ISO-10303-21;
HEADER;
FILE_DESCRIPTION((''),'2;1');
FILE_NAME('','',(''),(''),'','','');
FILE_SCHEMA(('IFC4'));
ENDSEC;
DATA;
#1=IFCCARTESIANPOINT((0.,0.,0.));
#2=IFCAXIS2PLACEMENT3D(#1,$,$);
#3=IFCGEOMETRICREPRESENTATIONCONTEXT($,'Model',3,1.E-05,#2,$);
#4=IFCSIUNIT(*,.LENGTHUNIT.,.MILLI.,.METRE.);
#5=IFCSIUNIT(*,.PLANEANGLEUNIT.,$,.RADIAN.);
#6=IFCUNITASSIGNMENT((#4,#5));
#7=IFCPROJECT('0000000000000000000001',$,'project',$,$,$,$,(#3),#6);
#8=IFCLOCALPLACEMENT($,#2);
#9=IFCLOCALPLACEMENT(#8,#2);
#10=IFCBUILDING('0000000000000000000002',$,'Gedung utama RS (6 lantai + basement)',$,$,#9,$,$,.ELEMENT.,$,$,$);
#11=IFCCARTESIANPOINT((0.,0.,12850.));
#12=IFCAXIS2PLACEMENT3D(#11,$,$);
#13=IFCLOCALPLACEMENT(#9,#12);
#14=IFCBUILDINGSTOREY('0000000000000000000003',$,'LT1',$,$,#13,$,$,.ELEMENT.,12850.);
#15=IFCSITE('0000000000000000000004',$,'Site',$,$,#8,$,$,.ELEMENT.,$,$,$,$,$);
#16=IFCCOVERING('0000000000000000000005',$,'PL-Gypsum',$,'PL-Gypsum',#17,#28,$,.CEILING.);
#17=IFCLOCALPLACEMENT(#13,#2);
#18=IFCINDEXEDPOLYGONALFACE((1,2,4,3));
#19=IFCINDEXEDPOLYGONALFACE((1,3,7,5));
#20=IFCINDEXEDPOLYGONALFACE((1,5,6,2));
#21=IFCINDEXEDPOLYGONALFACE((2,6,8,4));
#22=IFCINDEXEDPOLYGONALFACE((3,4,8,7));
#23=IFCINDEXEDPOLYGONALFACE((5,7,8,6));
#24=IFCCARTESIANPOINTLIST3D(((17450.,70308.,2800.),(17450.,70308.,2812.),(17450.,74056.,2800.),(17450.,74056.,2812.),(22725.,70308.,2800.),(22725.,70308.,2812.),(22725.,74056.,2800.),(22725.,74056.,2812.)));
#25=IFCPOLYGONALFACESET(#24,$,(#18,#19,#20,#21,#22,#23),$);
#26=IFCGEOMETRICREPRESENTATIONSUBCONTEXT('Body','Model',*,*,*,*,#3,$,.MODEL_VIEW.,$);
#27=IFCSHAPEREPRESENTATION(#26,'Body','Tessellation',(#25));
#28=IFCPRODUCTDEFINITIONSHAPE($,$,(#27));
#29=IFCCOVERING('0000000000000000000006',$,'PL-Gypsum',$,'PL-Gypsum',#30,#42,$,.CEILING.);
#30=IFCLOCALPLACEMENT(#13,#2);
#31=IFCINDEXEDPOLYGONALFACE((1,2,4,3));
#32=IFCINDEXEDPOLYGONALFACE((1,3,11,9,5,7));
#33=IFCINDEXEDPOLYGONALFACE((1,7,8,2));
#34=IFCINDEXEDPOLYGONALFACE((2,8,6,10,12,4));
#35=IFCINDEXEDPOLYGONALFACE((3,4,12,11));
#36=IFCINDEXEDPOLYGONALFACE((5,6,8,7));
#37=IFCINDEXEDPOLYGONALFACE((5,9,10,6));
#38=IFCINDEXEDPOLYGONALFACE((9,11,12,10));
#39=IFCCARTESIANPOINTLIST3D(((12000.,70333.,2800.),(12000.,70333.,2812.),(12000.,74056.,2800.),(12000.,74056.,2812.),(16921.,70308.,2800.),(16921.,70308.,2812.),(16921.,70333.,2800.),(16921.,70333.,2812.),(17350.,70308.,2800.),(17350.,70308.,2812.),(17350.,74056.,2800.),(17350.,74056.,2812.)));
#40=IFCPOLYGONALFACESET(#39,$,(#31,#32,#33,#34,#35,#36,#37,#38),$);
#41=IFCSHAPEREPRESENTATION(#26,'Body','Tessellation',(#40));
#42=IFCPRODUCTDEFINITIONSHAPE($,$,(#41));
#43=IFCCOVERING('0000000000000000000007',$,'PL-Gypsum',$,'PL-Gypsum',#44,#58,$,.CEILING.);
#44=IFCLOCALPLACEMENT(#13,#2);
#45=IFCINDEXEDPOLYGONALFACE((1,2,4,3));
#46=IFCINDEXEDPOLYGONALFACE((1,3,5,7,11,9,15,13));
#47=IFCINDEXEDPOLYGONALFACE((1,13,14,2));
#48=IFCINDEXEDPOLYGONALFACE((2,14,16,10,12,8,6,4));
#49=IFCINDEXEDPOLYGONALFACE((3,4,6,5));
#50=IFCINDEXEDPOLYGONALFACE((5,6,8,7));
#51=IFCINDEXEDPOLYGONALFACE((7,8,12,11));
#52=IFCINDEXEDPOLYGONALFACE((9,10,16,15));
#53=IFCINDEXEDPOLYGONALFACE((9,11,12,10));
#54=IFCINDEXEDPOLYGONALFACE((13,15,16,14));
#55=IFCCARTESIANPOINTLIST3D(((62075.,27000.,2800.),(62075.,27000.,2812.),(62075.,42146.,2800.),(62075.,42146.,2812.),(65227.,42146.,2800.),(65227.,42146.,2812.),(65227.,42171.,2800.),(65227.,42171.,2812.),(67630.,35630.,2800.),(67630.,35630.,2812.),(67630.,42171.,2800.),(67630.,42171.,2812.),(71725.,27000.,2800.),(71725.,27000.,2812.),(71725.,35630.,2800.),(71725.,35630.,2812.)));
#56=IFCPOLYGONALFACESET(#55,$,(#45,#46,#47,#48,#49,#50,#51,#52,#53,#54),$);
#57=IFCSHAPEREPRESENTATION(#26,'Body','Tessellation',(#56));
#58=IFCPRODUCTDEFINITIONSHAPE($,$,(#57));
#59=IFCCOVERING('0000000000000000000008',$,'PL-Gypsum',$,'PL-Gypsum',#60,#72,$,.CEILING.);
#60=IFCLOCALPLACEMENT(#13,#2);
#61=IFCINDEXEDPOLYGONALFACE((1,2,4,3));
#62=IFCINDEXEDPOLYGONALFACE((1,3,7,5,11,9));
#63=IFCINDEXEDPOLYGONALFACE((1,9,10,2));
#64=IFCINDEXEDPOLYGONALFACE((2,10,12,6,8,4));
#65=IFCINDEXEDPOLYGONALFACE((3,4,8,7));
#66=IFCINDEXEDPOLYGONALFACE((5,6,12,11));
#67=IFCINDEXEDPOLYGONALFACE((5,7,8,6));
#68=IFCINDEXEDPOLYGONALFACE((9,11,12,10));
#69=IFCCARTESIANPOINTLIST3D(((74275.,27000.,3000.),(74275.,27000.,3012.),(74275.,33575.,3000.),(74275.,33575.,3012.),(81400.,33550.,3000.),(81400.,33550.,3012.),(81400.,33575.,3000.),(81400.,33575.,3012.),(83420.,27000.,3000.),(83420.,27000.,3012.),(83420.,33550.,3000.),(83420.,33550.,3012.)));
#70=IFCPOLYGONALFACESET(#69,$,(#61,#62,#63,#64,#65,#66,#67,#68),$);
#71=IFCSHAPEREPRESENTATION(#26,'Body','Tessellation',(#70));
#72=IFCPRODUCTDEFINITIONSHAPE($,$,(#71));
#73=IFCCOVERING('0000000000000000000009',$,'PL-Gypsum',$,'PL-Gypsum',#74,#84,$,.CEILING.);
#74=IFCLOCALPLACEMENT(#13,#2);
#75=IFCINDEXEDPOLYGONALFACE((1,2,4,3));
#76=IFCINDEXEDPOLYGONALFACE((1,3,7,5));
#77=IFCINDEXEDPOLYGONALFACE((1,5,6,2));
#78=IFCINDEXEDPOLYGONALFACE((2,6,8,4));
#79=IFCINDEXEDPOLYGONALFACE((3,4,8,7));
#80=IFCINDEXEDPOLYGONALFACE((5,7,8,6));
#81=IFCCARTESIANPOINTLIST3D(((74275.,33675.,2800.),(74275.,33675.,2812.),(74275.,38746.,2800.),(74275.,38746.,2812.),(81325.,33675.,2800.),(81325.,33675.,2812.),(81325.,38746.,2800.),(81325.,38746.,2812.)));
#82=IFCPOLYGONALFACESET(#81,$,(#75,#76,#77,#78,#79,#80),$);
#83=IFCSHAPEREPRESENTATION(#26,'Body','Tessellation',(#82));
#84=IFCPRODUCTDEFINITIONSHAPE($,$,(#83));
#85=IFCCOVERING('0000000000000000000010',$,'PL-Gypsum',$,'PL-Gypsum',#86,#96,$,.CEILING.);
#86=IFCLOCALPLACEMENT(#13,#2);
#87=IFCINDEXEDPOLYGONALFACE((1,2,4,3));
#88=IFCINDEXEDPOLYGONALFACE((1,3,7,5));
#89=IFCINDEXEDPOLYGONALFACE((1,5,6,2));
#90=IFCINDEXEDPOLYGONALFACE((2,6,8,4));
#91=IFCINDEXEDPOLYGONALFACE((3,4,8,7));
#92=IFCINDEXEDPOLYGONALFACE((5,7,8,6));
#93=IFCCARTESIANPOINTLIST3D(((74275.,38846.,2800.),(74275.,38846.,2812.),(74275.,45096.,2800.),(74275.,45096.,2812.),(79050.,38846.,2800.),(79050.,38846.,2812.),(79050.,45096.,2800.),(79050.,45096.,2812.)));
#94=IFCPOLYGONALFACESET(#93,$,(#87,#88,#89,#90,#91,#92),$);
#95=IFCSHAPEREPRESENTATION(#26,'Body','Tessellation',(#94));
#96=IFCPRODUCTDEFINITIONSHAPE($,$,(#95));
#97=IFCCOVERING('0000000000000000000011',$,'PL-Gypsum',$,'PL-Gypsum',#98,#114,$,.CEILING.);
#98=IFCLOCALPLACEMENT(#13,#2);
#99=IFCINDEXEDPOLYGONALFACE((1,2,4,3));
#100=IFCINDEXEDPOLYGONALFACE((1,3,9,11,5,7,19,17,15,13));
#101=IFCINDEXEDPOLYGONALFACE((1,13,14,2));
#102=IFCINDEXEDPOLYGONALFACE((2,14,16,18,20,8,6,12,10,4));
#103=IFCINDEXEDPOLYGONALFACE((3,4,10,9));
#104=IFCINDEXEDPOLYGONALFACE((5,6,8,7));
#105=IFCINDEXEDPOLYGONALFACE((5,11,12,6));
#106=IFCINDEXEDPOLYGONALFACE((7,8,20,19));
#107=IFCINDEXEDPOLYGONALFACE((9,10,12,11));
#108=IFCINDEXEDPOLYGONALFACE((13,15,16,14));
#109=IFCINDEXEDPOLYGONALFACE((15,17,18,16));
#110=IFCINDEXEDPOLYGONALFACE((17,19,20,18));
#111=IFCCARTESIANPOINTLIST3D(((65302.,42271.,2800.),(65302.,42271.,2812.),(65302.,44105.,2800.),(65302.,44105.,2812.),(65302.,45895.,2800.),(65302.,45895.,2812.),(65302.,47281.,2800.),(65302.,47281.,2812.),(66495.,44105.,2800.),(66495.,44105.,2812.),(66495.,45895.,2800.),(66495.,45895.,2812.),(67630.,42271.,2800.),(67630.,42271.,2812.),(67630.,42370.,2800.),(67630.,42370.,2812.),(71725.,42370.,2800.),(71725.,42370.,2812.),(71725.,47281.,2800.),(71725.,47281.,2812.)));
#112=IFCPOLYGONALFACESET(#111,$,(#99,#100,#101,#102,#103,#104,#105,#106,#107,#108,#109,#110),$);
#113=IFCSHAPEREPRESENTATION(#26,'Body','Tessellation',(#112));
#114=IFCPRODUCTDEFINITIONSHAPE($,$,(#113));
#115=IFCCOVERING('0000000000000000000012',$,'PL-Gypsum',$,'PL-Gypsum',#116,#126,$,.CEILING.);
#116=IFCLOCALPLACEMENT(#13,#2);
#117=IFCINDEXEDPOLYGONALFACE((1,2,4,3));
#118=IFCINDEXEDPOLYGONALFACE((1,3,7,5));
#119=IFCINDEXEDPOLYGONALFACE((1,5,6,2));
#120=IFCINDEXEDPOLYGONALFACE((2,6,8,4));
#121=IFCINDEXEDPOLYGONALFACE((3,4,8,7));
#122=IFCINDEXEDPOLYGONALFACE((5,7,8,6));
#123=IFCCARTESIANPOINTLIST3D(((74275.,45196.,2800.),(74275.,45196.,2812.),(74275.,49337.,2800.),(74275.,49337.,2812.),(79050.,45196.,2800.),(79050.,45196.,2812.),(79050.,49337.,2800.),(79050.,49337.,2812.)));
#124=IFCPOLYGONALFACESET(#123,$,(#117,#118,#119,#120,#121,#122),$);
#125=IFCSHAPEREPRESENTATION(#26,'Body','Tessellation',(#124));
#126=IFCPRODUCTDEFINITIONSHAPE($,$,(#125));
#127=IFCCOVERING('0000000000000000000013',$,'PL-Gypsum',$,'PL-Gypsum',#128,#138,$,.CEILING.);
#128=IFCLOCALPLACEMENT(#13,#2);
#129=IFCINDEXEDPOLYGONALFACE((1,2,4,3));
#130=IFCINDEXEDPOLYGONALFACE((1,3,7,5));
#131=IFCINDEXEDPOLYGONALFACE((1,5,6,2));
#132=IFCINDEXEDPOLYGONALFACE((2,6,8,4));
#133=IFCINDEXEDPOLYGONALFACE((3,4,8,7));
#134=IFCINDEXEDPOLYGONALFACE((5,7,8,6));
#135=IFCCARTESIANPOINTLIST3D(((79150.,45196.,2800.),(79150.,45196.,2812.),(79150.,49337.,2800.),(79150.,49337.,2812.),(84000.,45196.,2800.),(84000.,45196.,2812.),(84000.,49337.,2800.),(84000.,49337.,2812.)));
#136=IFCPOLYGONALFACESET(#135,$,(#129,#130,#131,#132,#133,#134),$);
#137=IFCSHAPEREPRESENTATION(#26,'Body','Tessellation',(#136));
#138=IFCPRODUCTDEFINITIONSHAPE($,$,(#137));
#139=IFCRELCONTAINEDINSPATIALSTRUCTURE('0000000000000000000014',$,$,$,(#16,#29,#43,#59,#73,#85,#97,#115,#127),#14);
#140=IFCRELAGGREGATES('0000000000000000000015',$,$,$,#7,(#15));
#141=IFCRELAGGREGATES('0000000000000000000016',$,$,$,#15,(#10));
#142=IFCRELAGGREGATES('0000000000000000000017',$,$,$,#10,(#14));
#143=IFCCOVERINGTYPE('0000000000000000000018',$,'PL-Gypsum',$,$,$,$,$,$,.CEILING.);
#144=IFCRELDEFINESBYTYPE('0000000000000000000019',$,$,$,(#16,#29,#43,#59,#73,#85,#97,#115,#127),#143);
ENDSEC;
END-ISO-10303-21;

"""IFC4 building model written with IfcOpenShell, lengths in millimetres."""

from ifc_helpers import new_model, si_unit, frame, origin, place, context, subcontext, project, spatial, polyline, outline, extrude, type_object, element, save


model = new_model("IFC4")

# Units and contexts
model_context = context("Model", 3, precision=1e-05, world=origin())
body_context = subcontext(model_context, "Body", "Model", "MODEL_VIEW")
ifc_project = project(units=[si_unit("LENGTHUNIT", "METRE", prefix="MILLI"), si_unit("PLANEANGLEUNIT", "RADIAN")], contexts=[model_context])

# Site, building, storey
site_placement = place(None, origin())
site = spatial("IfcSite", under=ifc_project, at=site_placement, Name="Site", CompositionType="ELEMENT")
building_placement = place(site_placement, origin())
building = spatial("IfcBuilding", under=site, at=building_placement, Name="Gedung utama RS (6 lantai + basement)", CompositionType="ELEMENT")
storey_placement = place(building_placement, frame((0.0, 0.0, 12850.0)))
storey = spatial("IfcBuildingStorey", under=building, at=storey_placement, Name="LT1", CompositionType="ELEMENT", Elevation=12850.0)

# Coverings
covering_type = type_object("IfcCoveringType", Name="PL-Gypsum", PredefinedType="CEILING")
covering_1_placement = place(storey_placement, origin())
element("IfcCovering", 1, at=covering_1_placement, inside=storey, type_object=covering_type, Name="PL-Gypsum", ObjectType="PL-Gypsum", PredefinedType="CEILING", context=body_context, shape_type="SweptSolid", body=[
    extrude(outline(polyline([(17450.0, 70308.0), (22725.0, 70308.0), (22725.0, 74056.0), (17450.0, 74056.0), (17450.0, 70308.0)])), frame((0.0, 0.0, 2800.0)), (0.0, 0.0, 1.0), 12.0),
])
covering_2_placement = place(storey_placement, origin())
element("IfcCovering", 2, at=covering_2_placement, inside=storey, type_object=covering_type, Name="PL-Gypsum", ObjectType="PL-Gypsum", PredefinedType="CEILING", context=body_context, shape_type="SweptSolid", body=[
    extrude(outline(polyline([(16921.0, 70308.0), (17350.0, 70308.0), (17350.0, 74056.0), (12000.0, 74056.0), (12000.0, 70333.0), (16921.0, 70333.0), (16921.0, 70308.0)])), frame((0.0, 0.0, 2800.0)), (0.0, 0.0, 1.0), 12.0),
])
covering_3_placement = place(storey_placement, origin())
element("IfcCovering", 3, at=covering_3_placement, inside=storey, type_object=covering_type, Name="PL-Gypsum", ObjectType="PL-Gypsum", PredefinedType="CEILING", context=body_context, shape_type="SweptSolid", body=[
    extrude(outline(polyline([(62075.0, 27000.0), (71725.0, 27000.0), (71725.0, 35630.0), (67630.0, 35630.0), (67630.0, 42171.0), (65227.0, 42171.0), (65227.0, 42146.0), (62075.0, 42146.0), (62075.0, 27000.0)])), frame((0.0, 0.0, 2800.0)), (0.0, 0.0, 1.0), 12.0),
])
covering_4_placement = place(storey_placement, origin())
element("IfcCovering", 4, at=covering_4_placement, inside=storey, type_object=covering_type, Name="PL-Gypsum", ObjectType="PL-Gypsum", PredefinedType="CEILING", context=body_context, shape_type="SweptSolid", body=[
    extrude(outline(polyline([(74275.0, 27000.0), (83420.0, 27000.0), (83420.0, 33550.0), (81400.0, 33550.0), (81400.0, 33575.0), (74275.0, 33575.0), (74275.0, 27000.0)])), frame((0.0, 0.0, 3000.0)), (0.0, 0.0, 1.0), 12.0),
])
covering_5_placement = place(storey_placement, origin())
element("IfcCovering", 5, at=covering_5_placement, inside=storey, type_object=covering_type, Name="PL-Gypsum", ObjectType="PL-Gypsum", PredefinedType="CEILING", context=body_context, shape_type="SweptSolid", body=[
    extrude(outline(polyline([(74275.0, 33675.0), (81325.0, 33675.0), (81325.0, 38746.0), (74275.0, 38746.0), (74275.0, 33675.0)])), frame((0.0, 0.0, 2800.0)), (0.0, 0.0, 1.0), 12.0),
])
covering_6_placement = place(storey_placement, origin())
element("IfcCovering", 6, at=covering_6_placement, inside=storey, type_object=covering_type, Name="PL-Gypsum", ObjectType="PL-Gypsum", PredefinedType="CEILING", context=body_context, shape_type="SweptSolid", body=[
    extrude(outline(polyline([(74275.0, 38846.0), (79050.0, 38846.0), (79050.0, 45096.0), (74275.0, 45096.0), (74275.0, 38846.0)])), frame((0.0, 0.0, 2800.0)), (0.0, 0.0, 1.0), 12.0),
])
covering_7_placement = place(storey_placement, origin())
element("IfcCovering", 7, at=covering_7_placement, inside=storey, type_object=covering_type, Name="PL-Gypsum", ObjectType="PL-Gypsum", PredefinedType="CEILING", context=body_context, shape_type="SweptSolid", body=[
    extrude(outline(polyline([(65302.0, 42271.0), (67630.0, 42271.0), (67630.0, 42370.0), (71725.0, 42370.0), (71725.0, 47281.0), (65302.0, 47281.0), (65302.0, 45895.0), (66495.0, 45895.0), (66495.0, 44105.0), (65302.0, 44105.0), (65302.0, 42271.0)])), frame((0.0, 0.0, 2800.0)), (0.0, 0.0, 1.0), 12.0),
])
covering_8_placement = place(storey_placement, origin())
element("IfcCovering", 8, at=covering_8_placement, inside=storey, type_object=covering_type, Name="PL-Gypsum", ObjectType="PL-Gypsum", PredefinedType="CEILING", context=body_context, shape_type="SweptSolid", body=[
    extrude(outline(polyline([(74275.0, 45196.0), (79050.0, 45196.0), (79050.0, 49337.0), (74275.0, 49337.0), (74275.0, 45196.0)])), frame((0.0, 0.0, 2800.0)), (0.0, 0.0, 1.0), 12.0),
])
covering_9_placement = place(storey_placement, origin())
element("IfcCovering", 9, at=covering_9_placement, inside=storey, type_object=covering_type, Name="PL-Gypsum", ObjectType="PL-Gypsum", PredefinedType="CEILING", context=body_context, shape_type="SweptSolid", body=[
    extrude(outline(polyline([(79150.0, 45196.0), (84000.0, 45196.0), (84000.0, 49337.0), (79150.0, 49337.0), (79150.0, 45196.0)])), frame((0.0, 0.0, 2800.0)), (0.0, 0.0, 1.0), 12.0),
])

save(model, "model.ifc")
